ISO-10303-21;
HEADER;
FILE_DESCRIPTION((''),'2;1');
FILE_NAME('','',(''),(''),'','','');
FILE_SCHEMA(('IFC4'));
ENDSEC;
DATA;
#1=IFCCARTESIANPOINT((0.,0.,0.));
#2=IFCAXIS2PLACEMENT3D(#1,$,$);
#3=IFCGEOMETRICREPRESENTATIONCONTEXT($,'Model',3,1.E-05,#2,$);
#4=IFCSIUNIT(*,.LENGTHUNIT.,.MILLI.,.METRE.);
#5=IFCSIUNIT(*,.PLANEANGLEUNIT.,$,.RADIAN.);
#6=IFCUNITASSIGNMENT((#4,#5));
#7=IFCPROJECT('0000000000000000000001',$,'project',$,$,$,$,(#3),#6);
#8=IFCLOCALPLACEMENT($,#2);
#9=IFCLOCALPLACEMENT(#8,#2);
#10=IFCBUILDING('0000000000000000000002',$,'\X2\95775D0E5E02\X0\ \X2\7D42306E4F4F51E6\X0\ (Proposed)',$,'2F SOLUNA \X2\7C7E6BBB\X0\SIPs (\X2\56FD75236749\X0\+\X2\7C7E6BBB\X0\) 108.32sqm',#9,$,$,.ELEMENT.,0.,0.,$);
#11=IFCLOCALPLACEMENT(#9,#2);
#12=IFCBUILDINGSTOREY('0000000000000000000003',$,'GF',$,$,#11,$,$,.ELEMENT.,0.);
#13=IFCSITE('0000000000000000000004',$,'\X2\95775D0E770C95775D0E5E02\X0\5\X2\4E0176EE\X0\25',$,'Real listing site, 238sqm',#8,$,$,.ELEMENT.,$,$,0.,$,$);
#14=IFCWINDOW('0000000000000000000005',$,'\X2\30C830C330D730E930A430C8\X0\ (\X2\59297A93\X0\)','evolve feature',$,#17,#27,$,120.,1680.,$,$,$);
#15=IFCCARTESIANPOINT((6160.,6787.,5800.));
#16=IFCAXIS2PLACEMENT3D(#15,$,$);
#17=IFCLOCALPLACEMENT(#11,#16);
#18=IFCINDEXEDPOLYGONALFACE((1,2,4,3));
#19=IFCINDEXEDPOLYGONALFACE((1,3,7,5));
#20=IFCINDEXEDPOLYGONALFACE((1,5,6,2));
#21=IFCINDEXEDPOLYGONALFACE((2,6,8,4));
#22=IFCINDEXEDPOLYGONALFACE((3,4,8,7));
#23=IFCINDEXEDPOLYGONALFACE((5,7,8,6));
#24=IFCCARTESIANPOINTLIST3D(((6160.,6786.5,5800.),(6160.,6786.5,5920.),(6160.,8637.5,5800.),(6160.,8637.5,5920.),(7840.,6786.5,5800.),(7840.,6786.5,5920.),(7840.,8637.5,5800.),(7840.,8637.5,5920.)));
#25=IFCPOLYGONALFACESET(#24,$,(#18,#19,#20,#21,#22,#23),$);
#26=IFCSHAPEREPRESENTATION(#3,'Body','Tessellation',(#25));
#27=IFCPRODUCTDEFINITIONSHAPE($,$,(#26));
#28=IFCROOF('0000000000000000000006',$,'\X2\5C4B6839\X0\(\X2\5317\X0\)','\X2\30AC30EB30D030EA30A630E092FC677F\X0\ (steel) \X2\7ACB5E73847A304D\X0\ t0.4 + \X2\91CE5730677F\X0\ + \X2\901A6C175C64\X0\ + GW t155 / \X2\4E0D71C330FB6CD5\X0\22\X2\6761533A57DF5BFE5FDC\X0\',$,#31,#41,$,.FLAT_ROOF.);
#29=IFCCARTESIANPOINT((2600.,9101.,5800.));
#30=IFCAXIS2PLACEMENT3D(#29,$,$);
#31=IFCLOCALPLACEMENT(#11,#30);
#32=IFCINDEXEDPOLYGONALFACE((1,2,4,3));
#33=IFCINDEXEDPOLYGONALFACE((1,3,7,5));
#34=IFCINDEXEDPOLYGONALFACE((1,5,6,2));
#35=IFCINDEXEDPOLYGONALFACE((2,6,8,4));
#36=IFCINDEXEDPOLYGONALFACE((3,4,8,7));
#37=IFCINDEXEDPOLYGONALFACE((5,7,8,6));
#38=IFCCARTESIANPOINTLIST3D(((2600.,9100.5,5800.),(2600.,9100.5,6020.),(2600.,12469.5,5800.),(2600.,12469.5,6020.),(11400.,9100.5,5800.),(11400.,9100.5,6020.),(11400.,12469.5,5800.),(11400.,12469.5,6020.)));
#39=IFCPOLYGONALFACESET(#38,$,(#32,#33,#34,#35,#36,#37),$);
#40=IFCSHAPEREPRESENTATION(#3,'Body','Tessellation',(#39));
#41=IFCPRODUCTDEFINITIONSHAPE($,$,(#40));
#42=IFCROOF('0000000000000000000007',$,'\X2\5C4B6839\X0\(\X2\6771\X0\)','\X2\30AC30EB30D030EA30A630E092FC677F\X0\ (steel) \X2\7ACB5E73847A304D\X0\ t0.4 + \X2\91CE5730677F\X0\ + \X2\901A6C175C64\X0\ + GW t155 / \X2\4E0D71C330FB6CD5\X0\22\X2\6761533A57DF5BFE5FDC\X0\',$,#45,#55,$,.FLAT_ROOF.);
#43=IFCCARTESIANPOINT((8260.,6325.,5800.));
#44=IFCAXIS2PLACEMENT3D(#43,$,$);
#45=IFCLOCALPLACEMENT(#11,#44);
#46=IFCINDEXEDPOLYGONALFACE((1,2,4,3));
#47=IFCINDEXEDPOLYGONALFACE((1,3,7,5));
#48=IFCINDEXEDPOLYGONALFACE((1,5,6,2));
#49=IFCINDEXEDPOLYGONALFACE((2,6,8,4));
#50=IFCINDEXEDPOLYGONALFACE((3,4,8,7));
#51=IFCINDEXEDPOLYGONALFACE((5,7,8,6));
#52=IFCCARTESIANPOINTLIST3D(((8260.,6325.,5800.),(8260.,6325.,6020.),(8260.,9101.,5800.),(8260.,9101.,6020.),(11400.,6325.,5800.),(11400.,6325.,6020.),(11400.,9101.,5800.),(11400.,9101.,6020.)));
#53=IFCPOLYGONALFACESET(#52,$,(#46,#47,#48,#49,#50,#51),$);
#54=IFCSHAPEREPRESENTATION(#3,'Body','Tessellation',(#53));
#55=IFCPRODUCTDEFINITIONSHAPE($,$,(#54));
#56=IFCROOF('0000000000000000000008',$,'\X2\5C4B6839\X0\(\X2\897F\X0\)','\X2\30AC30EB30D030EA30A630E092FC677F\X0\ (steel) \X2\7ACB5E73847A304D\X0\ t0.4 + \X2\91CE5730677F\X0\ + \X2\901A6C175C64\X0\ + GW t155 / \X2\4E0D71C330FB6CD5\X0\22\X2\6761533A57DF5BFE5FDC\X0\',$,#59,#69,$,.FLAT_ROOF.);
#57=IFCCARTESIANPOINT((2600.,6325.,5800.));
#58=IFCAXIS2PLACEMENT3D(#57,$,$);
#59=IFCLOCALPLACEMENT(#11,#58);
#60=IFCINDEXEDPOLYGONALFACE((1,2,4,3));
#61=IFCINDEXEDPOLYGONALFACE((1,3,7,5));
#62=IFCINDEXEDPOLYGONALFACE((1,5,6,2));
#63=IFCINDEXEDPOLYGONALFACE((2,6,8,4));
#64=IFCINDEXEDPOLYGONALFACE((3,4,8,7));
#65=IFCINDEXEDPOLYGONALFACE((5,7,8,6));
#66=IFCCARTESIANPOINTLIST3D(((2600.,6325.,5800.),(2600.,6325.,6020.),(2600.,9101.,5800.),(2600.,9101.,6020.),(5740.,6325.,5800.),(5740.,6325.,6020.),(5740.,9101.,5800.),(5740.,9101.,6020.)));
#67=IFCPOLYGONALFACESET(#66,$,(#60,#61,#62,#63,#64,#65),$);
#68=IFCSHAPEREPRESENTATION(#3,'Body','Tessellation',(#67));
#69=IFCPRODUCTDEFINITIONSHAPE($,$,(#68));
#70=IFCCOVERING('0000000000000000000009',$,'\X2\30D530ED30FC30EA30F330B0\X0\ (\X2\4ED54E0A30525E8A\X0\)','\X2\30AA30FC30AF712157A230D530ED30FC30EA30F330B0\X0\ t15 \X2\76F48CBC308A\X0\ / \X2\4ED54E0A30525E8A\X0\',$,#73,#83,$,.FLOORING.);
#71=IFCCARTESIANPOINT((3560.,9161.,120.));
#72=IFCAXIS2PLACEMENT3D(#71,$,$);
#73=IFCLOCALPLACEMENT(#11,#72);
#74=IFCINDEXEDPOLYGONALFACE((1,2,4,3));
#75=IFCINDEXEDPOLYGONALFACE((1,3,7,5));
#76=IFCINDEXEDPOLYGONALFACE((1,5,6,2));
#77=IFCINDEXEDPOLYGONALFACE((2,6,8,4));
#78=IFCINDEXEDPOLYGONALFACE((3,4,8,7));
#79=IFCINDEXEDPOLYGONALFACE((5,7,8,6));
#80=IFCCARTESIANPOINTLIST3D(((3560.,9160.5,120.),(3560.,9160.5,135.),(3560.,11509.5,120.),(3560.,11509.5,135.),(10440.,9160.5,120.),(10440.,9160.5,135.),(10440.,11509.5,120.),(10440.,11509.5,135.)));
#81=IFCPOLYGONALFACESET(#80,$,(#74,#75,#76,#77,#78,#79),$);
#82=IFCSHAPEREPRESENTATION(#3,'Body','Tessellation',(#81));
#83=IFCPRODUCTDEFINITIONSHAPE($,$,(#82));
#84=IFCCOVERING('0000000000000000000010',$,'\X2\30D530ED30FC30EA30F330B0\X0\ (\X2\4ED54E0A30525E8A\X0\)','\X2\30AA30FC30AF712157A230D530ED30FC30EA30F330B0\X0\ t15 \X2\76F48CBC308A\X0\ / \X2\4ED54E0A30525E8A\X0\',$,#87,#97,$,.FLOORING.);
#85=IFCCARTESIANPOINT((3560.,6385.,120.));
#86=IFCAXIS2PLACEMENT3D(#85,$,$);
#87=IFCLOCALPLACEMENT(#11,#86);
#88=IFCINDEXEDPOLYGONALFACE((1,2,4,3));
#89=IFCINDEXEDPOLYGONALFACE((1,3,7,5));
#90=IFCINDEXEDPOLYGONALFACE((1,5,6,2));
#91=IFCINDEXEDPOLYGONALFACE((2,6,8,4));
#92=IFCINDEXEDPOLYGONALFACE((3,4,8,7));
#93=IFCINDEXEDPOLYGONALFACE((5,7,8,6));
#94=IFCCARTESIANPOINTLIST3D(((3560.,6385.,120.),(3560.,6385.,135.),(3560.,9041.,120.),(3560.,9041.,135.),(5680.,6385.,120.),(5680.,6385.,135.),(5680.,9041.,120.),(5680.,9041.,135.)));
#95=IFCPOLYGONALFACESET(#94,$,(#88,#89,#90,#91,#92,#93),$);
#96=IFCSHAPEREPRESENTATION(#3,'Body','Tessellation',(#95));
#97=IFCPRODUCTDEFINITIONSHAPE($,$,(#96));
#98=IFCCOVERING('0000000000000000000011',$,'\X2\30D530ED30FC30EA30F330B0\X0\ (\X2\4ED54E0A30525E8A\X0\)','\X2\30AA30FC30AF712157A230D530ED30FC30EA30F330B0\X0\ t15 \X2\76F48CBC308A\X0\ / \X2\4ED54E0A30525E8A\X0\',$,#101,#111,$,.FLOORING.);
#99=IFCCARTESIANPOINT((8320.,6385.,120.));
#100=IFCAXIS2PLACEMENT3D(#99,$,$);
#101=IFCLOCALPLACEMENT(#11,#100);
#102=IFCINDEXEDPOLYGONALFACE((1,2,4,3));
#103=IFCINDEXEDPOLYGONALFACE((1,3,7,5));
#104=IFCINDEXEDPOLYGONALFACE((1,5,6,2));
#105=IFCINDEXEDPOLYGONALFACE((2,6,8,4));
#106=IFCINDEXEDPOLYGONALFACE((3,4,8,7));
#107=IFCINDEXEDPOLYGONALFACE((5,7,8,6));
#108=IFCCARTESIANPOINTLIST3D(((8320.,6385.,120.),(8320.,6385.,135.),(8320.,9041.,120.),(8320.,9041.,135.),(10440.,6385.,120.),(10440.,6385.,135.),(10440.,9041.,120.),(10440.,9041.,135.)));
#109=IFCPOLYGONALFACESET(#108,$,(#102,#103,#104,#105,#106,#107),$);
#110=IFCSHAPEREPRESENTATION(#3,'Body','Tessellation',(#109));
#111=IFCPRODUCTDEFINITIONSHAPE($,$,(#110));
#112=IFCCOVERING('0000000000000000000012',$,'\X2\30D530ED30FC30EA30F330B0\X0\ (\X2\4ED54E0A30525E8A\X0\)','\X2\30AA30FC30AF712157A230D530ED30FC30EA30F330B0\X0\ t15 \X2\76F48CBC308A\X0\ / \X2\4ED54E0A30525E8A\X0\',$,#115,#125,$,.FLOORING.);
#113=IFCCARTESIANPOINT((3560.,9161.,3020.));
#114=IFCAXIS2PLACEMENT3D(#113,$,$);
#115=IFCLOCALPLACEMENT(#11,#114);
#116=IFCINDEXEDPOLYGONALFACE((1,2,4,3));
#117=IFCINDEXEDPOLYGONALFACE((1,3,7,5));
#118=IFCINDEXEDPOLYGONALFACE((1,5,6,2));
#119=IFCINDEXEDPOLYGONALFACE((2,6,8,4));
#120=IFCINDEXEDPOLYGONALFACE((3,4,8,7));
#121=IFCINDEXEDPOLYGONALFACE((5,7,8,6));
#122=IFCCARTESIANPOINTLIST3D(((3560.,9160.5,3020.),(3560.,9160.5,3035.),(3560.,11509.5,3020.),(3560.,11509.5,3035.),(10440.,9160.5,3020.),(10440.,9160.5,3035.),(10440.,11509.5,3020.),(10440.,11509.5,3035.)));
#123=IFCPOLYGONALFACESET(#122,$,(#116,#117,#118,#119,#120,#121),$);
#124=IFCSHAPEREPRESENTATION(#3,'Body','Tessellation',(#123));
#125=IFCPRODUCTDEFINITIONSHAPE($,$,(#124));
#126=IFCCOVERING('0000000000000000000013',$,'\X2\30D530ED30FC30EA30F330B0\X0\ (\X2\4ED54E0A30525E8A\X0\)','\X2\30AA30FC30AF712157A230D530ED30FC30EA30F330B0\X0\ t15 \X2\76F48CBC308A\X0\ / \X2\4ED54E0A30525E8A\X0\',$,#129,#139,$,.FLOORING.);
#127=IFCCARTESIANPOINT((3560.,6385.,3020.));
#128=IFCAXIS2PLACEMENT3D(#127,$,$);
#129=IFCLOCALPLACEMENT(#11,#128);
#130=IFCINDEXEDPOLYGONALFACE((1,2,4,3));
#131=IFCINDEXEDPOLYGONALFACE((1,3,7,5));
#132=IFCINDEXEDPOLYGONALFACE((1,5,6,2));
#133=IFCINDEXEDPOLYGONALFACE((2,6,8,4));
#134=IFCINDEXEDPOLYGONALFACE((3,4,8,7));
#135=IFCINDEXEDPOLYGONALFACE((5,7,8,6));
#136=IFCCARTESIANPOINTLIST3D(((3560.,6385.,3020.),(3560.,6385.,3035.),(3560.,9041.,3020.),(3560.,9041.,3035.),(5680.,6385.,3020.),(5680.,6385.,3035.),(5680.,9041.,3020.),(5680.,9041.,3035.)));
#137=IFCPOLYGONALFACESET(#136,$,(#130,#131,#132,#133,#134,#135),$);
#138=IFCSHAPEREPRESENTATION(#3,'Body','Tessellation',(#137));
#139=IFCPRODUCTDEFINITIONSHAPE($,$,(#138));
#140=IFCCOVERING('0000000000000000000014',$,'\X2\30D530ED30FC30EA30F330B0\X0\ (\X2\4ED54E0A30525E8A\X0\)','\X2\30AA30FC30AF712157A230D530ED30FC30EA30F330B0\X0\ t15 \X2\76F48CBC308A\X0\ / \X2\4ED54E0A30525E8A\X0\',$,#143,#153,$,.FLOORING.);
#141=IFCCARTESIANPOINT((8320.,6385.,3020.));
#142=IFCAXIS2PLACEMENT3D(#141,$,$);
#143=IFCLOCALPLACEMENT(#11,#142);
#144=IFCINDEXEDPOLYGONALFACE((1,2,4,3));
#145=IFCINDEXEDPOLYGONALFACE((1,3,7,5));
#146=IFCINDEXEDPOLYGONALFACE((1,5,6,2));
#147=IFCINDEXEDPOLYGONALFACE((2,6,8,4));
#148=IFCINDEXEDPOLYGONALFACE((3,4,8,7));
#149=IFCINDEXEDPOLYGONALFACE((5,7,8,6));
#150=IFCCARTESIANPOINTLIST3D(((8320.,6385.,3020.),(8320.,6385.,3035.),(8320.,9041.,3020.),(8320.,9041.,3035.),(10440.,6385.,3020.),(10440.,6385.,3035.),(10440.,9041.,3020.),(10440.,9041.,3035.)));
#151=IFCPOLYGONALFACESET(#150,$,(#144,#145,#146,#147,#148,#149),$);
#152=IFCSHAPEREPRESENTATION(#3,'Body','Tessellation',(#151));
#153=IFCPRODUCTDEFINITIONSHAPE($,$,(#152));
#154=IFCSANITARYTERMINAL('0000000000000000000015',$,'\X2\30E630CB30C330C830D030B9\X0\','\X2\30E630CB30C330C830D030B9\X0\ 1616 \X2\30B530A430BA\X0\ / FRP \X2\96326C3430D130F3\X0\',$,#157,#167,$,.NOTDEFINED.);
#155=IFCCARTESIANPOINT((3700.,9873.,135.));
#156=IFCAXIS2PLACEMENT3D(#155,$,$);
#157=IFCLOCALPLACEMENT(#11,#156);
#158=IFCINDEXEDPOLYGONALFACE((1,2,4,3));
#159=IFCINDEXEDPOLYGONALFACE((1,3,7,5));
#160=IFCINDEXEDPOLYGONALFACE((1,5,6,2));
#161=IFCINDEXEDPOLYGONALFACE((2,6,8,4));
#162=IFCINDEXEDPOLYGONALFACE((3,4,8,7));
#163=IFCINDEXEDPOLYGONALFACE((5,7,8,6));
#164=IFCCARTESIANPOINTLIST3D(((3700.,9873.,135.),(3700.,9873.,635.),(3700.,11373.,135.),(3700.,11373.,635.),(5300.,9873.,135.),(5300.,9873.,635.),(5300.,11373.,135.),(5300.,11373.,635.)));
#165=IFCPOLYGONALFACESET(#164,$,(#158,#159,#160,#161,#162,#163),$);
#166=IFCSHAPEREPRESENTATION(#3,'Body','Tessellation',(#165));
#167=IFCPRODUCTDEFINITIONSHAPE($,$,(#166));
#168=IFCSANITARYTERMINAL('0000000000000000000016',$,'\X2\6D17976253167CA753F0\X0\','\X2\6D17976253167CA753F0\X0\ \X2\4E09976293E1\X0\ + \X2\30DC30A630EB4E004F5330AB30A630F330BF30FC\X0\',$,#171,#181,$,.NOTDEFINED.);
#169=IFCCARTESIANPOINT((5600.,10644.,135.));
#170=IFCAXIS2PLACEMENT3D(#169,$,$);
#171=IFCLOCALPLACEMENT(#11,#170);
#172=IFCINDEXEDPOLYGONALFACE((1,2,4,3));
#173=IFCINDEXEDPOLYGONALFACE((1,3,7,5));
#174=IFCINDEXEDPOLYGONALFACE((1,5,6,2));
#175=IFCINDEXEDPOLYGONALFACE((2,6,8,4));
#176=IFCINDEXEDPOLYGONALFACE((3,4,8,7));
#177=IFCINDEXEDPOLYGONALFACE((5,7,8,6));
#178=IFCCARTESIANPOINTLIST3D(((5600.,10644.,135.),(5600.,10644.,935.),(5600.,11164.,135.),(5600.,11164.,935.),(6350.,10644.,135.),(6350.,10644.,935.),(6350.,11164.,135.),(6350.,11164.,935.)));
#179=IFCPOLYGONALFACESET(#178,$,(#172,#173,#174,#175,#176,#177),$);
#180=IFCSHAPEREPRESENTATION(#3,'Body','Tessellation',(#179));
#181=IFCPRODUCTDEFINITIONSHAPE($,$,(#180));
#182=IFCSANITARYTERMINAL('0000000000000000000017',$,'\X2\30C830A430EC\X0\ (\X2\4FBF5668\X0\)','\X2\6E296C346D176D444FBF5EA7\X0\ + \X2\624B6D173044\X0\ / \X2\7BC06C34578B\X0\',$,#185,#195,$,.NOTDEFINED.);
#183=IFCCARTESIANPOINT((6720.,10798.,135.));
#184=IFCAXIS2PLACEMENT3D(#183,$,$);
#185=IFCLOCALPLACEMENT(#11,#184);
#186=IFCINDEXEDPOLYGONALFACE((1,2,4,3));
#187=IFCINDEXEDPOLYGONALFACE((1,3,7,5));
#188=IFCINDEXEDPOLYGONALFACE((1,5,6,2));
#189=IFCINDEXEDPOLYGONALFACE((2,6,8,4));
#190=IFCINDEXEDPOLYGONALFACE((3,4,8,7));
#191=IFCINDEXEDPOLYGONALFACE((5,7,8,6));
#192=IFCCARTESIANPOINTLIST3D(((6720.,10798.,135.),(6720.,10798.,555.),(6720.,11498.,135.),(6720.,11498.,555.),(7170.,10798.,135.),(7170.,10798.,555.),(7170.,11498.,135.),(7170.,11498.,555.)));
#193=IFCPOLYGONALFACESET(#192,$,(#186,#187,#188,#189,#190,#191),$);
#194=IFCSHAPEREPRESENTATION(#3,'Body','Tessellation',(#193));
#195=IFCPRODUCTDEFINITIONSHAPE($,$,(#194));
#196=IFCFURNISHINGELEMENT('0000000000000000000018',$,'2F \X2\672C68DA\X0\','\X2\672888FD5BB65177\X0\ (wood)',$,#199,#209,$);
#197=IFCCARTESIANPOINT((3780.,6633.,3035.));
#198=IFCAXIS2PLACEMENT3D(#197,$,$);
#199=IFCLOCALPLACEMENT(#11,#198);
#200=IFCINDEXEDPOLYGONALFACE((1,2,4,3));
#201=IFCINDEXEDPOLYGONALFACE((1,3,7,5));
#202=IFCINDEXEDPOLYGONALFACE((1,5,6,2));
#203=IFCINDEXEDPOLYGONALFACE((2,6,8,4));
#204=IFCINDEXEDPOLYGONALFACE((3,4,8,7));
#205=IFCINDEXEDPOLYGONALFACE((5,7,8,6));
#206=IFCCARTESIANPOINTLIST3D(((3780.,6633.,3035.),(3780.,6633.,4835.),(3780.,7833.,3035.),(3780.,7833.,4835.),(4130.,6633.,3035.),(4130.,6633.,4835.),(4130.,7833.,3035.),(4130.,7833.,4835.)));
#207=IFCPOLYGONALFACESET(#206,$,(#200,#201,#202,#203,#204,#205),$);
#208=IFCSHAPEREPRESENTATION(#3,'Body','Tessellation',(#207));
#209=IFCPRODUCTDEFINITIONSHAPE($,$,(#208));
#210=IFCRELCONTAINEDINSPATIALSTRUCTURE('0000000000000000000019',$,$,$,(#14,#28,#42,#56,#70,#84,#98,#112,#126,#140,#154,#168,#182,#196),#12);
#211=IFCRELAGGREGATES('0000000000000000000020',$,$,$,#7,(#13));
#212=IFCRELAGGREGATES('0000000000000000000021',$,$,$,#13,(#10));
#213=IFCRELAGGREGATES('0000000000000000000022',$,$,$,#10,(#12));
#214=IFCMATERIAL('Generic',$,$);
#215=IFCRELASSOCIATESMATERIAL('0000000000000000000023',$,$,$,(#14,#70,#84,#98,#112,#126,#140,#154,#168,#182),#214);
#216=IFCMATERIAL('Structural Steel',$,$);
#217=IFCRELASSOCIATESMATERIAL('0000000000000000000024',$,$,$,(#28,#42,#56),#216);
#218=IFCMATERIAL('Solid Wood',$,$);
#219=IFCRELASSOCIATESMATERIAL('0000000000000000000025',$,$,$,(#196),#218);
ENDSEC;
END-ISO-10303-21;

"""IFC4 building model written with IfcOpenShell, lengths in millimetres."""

from ifc_helpers import new_model, si_unit, frame, frame_2d, origin, place, context, project, spatial, rectangle, extrude, material, element, save


model = new_model("IFC4")

# Units and contexts
model_context = context("Model", 3, precision=1e-05, world=origin())
ifc_project = project(units=[si_unit("LENGTHUNIT", "METRE", prefix="MILLI"), si_unit("PLANEANGLEUNIT", "RADIAN")], contexts=[model_context])

# Site, building, storey
site_placement = place(None, origin())
site = spatial("IfcSite", under=ifc_project, at=site_placement, Name="長崎県長崎市5丁目25", ObjectType="Real listing site, 238sqm", CompositionType="ELEMENT", RefElevation=0.0)
building_placement = place(site_placement, origin())
building = spatial("IfcBuilding", under=site, at=building_placement, Name="長崎市 終の住処 (Proposed)", ObjectType="2F SOLUNA 籾殻SIPs (国産杉+籾殻) 108.32sqm", CompositionType="ELEMENT", ElevationOfRefHeight=0.0, ElevationOfTerrain=0.0)
storey_placement = place(building_placement, origin())
storey = spatial("IfcBuildingStorey", under=building, at=storey_placement, Name="GF", CompositionType="ELEMENT", Elevation=0.0)

# Shared definitions
ifc_material_1 = material(Name="Solid Wood")

# Window
ifc_material_2 = material(Name="Generic")
window_1_placement = place(storey_placement, frame((6160.0, 6787.0, 5800.0)))
element("IfcWindow", 1, at=window_1_placement, inside=storey, material=ifc_material_2, Name="トップライト (天窓)", Description="evolve feature", OverallHeight=120.0, OverallWidth=1680.0, context=model_context, shape_type="SweptSolid", body=[
    extrude(rectangle(XDim=1680.0, YDim=1851.0, at=frame_2d((840.0, 925.0))), frame((6160.0, 6787.0, 5800.0)), (0.0, 0.0, 1.0), 120.0),
])

# Roofs
ifc_material_3 = material(Name="Structural Steel")
roof_1_placement = place(storey_placement, frame((2600.0, 9101.0, 5800.0)))
element("IfcRoof", 2, at=roof_1_placement, inside=storey, material=ifc_material_3, Name="屋根(北)", Description="ガルバリウム鋼板 (steel) 立平葺き t0.4 + 野地板 + 通気層 + GW t155 / 不燃・法22条区域対応", PredefinedType="FLAT_ROOF", context=model_context, shape_type="SweptSolid", body=[
    extrude(rectangle(XDim=8800.0, YDim=3369.0, at=frame_2d((4400.0, 1684.0))), frame((2600.0, 9101.0, 5800.0)), (0.0, 0.0, 1.0), 220.0),
])
roof_2_placement = place(storey_placement, frame((8260.0, 6325.0, 5800.0)))
element("IfcRoof", 3, at=roof_2_placement, inside=storey, material=ifc_material_3, Name="屋根(東)", Description="ガルバリウム鋼板 (steel) 立平葺き t0.4 + 野地板 + 通気層 + GW t155 / 不燃・法22条区域対応", PredefinedType="FLAT_ROOF", context=model_context, shape_type="SweptSolid", body=[
    extrude(rectangle(XDim=3140.0, YDim=2776.0, at=frame_2d((1570.0, 1388.0))), frame((8260.0, 6325.0, 5800.0)), (0.0, 0.0, 1.0), 220.0),
])
roof_3_placement = place(storey_placement, frame((2600.0, 6325.0, 5800.0)))
element("IfcRoof", 4, at=roof_3_placement, inside=storey, material=ifc_material_3, Name="屋根(西)", Description="ガルバリウム鋼板 (steel) 立平葺き t0.4 + 野地板 + 通気層 + GW t155 / 不燃・法22条区域対応", PredefinedType="FLAT_ROOF", context=model_context, shape_type="SweptSolid", body=[
    extrude(rectangle(XDim=3140.0, YDim=2776.0, at=frame_2d((1570.0, 1388.0))), frame((2600.0, 6325.0, 5800.0)), (0.0, 0.0, 1.0), 220.0),
])

# Coverings
covering_1_placement = place(storey_placement, frame((3560.0, 9161.0, 120.0)))
element("IfcCovering", 5, at=covering_1_placement, inside=storey, material=ifc_material_2, Name="フローリング (仕上げ床)", Description="オーク無垢フローリング t15 直貼り / 仕上げ床", PredefinedType="FLOORING", context=model_context, shape_type="SweptSolid", body=[
    extrude(rectangle(XDim=6880.0, YDim=2349.0, at=frame_2d((3440.0, 1174.0))), frame((3560.0, 9161.0, 120.0)), (0.0, 0.0, 1.0), 15.0),
])
covering_2_placement = place(storey_placement, frame((3560.0, 6385.0, 120.0)))
element("IfcCovering", 6, at=covering_2_placement, inside=storey, material=ifc_material_2, Name="フローリング (仕上げ床)", Description="オーク無垢フローリング t15 直貼り / 仕上げ床", PredefinedType="FLOORING", context=model_context, shape_type="SweptSolid", body=[
    extrude(rectangle(XDim=2120.0, YDim=2656.0, at=frame_2d((1060.0, 1328.0))), frame((3560.0, 6385.0, 120.0)), (0.0, 0.0, 1.0), 15.0),
])
covering_3_placement = place(storey_placement, frame((8320.0, 6385.0, 120.0)))
element("IfcCovering", 7, at=covering_3_placement, inside=storey, material=ifc_material_2, Name="フローリング (仕上げ床)", Description="オーク無垢フローリング t15 直貼り / 仕上げ床", PredefinedType="FLOORING", context=model_context, shape_type="SweptSolid", body=[
    extrude(rectangle(XDim=2120.0, YDim=2656.0, at=frame_2d((1060.0, 1328.0))), frame((8320.0, 6385.0, 120.0)), (0.0, 0.0, 1.0), 15.0),
])
covering_4_placement = place(storey_placement, frame((3560.0, 9161.0, 3020.0)))
element("IfcCovering", 8, at=covering_4_placement, inside=storey, material=ifc_material_2, Name="フローリング (仕上げ床)", Description="オーク無垢フローリング t15 直貼り / 仕上げ床", PredefinedType="FLOORING", context=model_context, shape_type="SweptSolid", body=[
    extrude(rectangle(XDim=6880.0, YDim=2349.0, at=frame_2d((3440.0, 1174.0))), frame((3560.0, 9161.0, 3020.0)), (0.0, 0.0, 1.0), 15.0),
])
covering_5_placement = place(storey_placement, frame((3560.0, 6385.0, 3020.0)))
element("IfcCovering", 9, at=covering_5_placement, inside=storey, material=ifc_material_2, Name="フローリング (仕上げ床)", Description="オーク無垢フローリング t15 直貼り / 仕上げ床", PredefinedType="FLOORING", context=model_context, shape_type="SweptSolid", body=[
    extrude(rectangle(XDim=2120.0, YDim=2656.0, at=frame_2d((1060.0, 1328.0))), frame((3560.0, 6385.0, 3020.0)), (0.0, 0.0, 1.0), 15.0),
])
covering_6_placement = place(storey_placement, frame((8320.0, 6385.0, 3020.0)))
element("IfcCovering", 10, at=covering_6_placement, inside=storey, material=ifc_material_2, Name="フローリング (仕上げ床)", Description="オーク無垢フローリング t15 直貼り / 仕上げ床", PredefinedType="FLOORING", context=model_context, shape_type="SweptSolid", body=[
    extrude(rectangle(XDim=2120.0, YDim=2656.0, at=frame_2d((1060.0, 1328.0))), frame((8320.0, 6385.0, 3020.0)), (0.0, 0.0, 1.0), 15.0),
])

# Sanitary terminals
sanitary_terminal_1_placement = place(storey_placement, frame((3700.0, 9873.0, 135.0)))
element("IfcSanitaryTerminal", 11, at=sanitary_terminal_1_placement, inside=storey, material=ifc_material_2, Name="ユニットバス", Description="ユニットバス 1616 サイズ / FRP 防水パン", PredefinedType="NOTDEFINED", context=model_context, shape_type="SweptSolid", body=[
    extrude(rectangle(XDim=1600.0, YDim=1500.0, at=frame_2d((800.0, 750.0))), frame((3700.0, 9873.0, 135.0)), (0.0, 0.0, 1.0), 500.0),
])
sanitary_terminal_2_placement = place(storey_placement, frame((5600.0, 10644.0, 135.0)))
element("IfcSanitaryTerminal", 12, at=sanitary_terminal_2_placement, inside=storey, material=ifc_material_2, Name="洗面化粧台", Description="洗面化粧台 三面鏡 + ボウル一体カウンター", PredefinedType="NOTDEFINED", context=model_context, shape_type="SweptSolid", body=[
    extrude(rectangle(XDim=750.0, YDim=520.0, at=frame_2d((375.0, 260.0))), frame((5600.0, 10644.0, 135.0)), (0.0, 0.0, 1.0), 800.0),
])
sanitary_terminal_3_placement = place(storey_placement, frame((6720.0, 10798.0, 135.0)))
element("IfcSanitaryTerminal", 13, at=sanitary_terminal_3_placement, inside=storey, material=ifc_material_2, Name="トイレ (便器)", Description="温水洗浄便座 + 手洗い / 節水型", PredefinedType="NOTDEFINED", context=model_context, shape_type="SweptSolid", body=[
    extrude(rectangle(XDim=450.0, YDim=700.0, at=frame_2d((225.0, 350.0))), frame((6720.0, 10798.0, 135.0)), (0.0, 0.0, 1.0), 420.0),
])

# Furnishing element
furnishing_placement = place(storey_placement, frame((3780.0, 6633.0, 3035.0)))
element("IfcFurnishingElement", 14, at=furnishing_placement, inside=storey, material=ifc_material_1, Name="2F 本棚", Description="木製家具 (wood)", context=model_context, shape_type="SweptSolid", body=[
    extrude(rectangle(XDim=350.0, YDim=1200.0, at=frame_2d((175.0, 600.0))), frame((3780.0, 6633.0, 3035.0)), (0.0, 0.0, 1.0), 1800.0),
])

save(model, "model.ifc")
